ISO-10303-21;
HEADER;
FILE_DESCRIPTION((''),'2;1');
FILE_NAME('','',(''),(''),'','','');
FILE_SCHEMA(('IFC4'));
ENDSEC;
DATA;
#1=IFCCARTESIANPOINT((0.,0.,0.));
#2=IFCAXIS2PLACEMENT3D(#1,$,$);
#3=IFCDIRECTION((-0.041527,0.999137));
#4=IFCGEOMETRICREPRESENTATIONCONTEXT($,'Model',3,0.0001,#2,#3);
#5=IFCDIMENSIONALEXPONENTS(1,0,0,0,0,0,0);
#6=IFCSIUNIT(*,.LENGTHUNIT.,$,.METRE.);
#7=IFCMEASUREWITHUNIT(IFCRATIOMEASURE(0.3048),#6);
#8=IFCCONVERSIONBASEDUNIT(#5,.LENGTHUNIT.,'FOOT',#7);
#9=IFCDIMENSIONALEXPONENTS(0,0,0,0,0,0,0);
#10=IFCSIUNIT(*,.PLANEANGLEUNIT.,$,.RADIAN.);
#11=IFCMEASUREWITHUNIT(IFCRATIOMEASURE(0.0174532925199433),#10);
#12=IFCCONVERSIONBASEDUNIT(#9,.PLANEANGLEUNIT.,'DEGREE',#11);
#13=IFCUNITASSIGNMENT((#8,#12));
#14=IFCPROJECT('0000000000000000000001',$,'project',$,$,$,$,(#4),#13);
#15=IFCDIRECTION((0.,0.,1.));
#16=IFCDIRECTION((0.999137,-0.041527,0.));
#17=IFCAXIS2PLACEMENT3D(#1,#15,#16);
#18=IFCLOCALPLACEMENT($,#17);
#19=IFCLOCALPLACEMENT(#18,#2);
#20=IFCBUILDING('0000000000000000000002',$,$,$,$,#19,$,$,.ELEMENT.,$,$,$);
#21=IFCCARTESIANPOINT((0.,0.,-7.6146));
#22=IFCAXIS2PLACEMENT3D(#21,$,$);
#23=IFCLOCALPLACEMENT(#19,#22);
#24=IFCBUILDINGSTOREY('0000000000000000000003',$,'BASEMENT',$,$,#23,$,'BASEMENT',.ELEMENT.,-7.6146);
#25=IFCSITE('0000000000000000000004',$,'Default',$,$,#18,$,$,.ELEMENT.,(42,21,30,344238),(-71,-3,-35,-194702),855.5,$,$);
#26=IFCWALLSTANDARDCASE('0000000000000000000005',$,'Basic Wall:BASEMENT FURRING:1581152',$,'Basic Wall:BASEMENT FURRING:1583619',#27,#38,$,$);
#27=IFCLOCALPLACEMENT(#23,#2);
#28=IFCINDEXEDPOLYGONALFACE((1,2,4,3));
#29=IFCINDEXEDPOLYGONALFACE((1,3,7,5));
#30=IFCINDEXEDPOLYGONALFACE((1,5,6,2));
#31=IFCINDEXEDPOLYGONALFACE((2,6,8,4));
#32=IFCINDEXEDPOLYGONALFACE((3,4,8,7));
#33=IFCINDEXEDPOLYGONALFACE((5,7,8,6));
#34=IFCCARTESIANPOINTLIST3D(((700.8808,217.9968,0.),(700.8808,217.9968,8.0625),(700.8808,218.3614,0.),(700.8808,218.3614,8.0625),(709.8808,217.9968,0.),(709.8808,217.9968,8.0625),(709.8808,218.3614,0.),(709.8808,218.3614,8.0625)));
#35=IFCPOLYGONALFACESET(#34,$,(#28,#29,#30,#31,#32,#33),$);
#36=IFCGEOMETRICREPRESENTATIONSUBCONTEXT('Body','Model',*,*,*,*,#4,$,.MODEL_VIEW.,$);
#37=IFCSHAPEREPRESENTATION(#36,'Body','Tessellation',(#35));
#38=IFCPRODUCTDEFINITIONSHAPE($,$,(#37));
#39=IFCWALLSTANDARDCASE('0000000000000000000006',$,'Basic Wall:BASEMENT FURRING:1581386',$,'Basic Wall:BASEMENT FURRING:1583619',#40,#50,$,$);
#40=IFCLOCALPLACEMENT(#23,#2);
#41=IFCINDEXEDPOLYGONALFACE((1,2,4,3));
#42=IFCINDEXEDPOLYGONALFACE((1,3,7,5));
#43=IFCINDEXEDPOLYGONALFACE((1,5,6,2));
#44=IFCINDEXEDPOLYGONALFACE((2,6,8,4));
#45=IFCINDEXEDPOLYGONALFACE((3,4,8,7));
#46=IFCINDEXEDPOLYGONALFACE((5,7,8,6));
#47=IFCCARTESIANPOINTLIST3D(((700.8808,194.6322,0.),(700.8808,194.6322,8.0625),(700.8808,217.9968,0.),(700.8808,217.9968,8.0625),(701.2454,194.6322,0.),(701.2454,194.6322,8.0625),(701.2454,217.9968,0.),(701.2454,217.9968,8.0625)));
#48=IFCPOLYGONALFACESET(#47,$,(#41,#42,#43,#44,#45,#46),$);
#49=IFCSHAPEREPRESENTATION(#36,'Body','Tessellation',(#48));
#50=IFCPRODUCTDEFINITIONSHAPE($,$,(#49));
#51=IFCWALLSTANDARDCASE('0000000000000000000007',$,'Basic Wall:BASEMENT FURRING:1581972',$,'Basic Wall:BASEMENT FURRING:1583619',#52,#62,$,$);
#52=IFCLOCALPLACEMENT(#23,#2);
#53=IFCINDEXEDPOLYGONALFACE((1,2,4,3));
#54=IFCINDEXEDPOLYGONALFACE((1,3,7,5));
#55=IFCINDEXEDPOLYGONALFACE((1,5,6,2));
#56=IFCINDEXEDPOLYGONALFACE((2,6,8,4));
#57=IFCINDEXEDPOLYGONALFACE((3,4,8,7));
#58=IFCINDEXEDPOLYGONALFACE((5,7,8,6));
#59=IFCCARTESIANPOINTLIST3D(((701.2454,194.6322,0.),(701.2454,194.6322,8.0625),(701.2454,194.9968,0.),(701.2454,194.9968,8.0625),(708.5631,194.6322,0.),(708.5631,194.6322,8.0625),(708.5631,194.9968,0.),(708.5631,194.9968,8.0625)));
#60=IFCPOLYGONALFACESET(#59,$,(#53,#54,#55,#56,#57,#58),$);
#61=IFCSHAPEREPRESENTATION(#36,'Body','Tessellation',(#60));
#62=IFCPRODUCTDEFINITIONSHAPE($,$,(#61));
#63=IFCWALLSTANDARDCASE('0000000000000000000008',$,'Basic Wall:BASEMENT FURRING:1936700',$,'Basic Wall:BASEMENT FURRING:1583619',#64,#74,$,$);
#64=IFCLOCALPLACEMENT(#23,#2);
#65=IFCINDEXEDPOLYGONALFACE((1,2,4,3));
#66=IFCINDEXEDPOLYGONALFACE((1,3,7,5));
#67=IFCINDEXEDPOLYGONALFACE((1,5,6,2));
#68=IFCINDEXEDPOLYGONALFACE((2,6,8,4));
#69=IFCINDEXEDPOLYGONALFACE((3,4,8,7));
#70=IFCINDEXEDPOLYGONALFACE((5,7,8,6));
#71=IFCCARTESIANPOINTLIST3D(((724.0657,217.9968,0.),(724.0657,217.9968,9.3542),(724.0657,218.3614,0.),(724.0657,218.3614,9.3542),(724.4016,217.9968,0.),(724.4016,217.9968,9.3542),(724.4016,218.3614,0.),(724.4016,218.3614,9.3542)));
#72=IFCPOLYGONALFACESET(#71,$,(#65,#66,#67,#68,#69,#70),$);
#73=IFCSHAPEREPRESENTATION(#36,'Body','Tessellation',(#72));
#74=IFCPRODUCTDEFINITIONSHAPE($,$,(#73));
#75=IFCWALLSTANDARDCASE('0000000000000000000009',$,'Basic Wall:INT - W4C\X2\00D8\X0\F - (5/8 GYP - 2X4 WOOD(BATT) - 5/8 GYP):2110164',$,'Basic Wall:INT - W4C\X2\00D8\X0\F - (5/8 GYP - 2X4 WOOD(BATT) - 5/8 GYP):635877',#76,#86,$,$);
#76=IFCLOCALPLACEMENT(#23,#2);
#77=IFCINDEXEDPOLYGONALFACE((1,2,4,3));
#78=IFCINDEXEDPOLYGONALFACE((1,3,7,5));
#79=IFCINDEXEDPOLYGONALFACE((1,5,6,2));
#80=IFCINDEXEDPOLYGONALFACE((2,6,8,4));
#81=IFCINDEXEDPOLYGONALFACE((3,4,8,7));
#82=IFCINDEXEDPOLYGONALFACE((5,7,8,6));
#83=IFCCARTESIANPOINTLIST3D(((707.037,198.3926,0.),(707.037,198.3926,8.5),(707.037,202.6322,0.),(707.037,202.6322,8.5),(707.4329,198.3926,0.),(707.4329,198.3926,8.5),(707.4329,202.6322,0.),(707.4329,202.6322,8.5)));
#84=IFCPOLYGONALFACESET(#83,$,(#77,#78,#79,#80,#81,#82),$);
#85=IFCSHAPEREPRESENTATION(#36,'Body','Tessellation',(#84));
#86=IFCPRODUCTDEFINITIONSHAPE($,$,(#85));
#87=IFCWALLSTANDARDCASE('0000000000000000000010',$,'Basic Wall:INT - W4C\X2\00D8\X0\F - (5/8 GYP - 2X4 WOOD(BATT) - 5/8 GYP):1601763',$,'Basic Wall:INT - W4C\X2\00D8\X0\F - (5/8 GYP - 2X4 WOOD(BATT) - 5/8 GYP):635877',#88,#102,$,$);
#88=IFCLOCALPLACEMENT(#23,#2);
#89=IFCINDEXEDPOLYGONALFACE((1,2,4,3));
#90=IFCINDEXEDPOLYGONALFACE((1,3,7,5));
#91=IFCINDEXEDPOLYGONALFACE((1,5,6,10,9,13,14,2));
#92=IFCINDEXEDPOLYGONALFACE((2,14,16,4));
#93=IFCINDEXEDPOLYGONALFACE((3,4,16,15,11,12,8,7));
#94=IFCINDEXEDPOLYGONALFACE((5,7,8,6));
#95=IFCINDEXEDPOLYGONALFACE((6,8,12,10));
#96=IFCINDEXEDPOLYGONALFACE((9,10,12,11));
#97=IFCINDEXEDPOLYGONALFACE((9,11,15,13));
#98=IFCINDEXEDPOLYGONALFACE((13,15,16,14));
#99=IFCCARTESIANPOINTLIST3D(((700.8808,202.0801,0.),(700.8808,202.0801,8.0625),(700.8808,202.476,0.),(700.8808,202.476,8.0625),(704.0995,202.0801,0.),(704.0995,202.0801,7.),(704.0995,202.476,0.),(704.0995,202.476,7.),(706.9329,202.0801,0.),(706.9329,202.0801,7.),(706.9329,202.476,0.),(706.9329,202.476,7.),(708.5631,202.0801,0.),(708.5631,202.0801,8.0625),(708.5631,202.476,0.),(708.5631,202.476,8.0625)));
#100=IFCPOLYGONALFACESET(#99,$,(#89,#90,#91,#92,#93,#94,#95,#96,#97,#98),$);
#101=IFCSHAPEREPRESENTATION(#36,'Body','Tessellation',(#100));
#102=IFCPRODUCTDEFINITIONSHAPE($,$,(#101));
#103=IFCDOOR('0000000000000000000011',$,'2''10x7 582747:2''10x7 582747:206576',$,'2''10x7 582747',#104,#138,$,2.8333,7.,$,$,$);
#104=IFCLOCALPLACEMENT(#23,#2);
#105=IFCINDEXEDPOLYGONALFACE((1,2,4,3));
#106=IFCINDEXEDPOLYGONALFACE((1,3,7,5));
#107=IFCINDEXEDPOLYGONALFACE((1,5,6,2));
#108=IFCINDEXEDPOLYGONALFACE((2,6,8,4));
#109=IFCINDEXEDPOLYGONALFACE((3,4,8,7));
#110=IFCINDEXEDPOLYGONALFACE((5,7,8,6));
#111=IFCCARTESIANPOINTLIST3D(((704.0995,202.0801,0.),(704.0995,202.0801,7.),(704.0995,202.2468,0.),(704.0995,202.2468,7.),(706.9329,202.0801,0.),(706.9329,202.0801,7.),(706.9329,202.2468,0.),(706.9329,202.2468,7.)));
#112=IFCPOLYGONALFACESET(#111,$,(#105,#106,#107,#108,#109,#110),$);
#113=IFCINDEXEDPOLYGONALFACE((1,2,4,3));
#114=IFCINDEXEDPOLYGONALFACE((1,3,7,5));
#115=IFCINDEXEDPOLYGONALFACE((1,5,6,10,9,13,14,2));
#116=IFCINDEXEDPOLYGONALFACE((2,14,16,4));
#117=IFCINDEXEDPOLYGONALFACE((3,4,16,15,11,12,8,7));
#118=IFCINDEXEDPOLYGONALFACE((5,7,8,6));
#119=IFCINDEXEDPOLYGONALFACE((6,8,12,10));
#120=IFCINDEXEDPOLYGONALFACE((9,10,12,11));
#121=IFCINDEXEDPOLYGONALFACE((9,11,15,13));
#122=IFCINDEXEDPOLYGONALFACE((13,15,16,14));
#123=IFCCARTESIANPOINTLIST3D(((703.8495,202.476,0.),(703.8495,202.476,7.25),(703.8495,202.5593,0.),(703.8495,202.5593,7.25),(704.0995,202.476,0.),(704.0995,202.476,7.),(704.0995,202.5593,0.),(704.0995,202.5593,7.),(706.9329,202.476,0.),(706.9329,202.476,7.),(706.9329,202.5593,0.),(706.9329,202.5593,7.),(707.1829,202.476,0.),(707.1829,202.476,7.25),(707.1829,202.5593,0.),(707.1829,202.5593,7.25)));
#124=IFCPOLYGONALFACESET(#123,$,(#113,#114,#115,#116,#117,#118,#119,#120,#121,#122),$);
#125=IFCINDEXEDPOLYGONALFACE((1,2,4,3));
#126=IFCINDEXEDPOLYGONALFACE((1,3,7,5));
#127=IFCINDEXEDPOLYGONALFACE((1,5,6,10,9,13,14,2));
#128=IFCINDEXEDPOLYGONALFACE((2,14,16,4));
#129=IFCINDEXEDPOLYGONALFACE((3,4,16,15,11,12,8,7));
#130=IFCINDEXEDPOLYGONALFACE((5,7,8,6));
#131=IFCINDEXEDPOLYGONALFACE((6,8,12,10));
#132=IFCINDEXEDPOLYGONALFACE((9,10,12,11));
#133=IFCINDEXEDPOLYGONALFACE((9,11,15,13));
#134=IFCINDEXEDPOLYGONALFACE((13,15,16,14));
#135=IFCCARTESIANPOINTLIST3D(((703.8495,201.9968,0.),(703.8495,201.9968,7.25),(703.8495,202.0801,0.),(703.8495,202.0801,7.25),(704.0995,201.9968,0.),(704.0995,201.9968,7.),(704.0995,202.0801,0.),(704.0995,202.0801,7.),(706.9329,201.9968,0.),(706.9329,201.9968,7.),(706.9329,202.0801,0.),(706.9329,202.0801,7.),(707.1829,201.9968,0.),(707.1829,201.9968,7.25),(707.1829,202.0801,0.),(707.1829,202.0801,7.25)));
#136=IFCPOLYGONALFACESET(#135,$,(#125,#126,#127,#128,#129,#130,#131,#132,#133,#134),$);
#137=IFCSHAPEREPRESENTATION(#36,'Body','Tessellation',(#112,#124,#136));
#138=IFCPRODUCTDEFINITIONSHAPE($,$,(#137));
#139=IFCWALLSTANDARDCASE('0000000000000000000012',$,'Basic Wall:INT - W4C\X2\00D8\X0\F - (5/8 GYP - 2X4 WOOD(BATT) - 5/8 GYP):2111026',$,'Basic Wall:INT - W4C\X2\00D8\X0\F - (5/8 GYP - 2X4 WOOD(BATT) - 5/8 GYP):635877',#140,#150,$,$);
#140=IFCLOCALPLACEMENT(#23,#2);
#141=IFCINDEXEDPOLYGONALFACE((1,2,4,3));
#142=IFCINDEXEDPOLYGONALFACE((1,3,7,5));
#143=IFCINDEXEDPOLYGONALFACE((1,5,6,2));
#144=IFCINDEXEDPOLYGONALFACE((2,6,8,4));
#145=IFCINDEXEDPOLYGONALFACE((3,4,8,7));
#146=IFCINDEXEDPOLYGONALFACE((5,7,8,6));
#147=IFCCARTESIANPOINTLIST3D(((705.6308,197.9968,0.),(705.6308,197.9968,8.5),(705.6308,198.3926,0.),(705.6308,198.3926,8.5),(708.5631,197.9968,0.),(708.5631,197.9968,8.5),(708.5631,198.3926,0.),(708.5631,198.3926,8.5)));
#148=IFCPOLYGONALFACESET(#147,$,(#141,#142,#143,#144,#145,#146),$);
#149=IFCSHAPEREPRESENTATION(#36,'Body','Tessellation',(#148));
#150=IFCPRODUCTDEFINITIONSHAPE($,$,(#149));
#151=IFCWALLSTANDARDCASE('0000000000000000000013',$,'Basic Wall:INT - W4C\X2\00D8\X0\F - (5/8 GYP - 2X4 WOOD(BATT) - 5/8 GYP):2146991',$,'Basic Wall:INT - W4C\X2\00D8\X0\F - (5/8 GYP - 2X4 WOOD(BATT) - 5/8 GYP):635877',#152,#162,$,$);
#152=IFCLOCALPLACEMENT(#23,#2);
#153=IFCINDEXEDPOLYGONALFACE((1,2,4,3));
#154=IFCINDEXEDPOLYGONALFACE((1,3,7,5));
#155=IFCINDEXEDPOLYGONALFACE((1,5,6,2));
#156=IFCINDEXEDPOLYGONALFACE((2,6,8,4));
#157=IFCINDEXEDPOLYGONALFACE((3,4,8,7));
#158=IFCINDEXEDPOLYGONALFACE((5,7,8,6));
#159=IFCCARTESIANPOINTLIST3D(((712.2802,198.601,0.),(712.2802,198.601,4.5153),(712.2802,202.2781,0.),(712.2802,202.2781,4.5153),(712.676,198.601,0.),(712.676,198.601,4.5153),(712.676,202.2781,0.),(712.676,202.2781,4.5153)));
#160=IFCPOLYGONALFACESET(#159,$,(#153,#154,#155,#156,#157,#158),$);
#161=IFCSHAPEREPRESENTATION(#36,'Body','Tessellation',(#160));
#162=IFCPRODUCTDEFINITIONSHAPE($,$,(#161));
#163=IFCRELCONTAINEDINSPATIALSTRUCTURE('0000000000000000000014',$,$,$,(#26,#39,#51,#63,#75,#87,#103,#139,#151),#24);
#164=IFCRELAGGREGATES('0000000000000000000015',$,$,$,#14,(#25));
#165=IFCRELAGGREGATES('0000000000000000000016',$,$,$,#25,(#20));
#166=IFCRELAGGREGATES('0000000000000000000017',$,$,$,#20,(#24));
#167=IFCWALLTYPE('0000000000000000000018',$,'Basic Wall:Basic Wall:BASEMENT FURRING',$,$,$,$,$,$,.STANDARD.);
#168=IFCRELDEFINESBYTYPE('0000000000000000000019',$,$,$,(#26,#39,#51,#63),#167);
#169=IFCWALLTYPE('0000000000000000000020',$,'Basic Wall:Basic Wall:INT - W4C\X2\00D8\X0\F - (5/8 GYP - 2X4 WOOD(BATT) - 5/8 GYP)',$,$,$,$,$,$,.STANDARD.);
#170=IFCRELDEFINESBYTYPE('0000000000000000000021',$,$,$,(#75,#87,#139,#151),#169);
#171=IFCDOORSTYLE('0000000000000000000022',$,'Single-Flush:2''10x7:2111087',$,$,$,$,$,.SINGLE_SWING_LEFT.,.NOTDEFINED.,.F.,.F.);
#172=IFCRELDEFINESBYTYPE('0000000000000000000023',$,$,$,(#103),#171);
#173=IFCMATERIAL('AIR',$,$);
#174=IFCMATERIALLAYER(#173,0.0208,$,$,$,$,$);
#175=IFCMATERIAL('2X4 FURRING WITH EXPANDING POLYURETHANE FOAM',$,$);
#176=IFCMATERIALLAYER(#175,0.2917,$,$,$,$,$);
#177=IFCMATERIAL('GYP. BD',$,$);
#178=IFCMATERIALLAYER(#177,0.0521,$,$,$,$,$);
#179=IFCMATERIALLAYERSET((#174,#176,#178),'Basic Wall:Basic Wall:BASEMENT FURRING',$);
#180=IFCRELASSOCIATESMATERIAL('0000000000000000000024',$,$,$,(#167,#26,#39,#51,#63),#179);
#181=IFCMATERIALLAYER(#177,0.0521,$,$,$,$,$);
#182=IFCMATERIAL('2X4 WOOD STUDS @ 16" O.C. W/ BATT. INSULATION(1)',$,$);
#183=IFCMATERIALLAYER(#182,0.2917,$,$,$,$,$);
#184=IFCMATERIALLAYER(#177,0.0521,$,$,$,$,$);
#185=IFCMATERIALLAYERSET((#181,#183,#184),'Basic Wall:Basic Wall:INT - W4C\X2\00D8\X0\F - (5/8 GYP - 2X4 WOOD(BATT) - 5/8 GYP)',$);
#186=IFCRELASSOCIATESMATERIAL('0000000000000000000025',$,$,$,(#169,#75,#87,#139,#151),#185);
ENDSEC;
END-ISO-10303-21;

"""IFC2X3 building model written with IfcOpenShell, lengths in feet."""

from ifc_helpers import new_model, entity, si_unit, converted_unit, direction, frame, frame_2d, origin, place, context, subcontext, project, spatial, polyline, rectangle, outline, extrude, source, transform, mapped, material, layer, layer_set, layer_usage, type_object, type_shapes, element, fill, save


model = new_model("IFC2X3")

# Units and contexts
model_context = context("Model", 3, precision=0.0001, world=origin(), true_north=direction((-0.041527, 0.999137)))
body_context = subcontext(model_context, "Body", "Model", "MODEL_VIEW")
ifc_project = project(units=[converted_unit("LENGTHUNIT", "FOOT", entity("IfcRatioMeasure", 0.3048), si_unit("LENGTHUNIT", "METRE"), dimensions=[1, 0, 0, 0, 0, 0, 0]), converted_unit("PLANEANGLEUNIT", "DEGREE", entity("IfcRatioMeasure", 0.0174532925199433), si_unit("PLANEANGLEUNIT", "RADIAN"), dimensions=[0, 0, 0, 0, 0, 0, 0])], contexts=[model_context])

# Site, building, storey
site_placement = place(None, frame((0.0, 0.0, 0.0), z_axis=(0.0, 0.0, 1.0), x_axis=(0.999137, -0.041527, 0.0)))
site = spatial("IfcSite", under=ifc_project, at=site_placement, Name="Default", CompositionType="ELEMENT", RefLatitude=(42, 21, 30, 344238), RefLongitude=(-71, -3, -35, -194702), RefElevation=855.5)
building_placement = place(site_placement, origin())
building = spatial("IfcBuilding", under=site, at=building_placement, CompositionType="ELEMENT")
storey_placement = place(building_placement, frame((0.0, 0.0, -7.6146)))
storey = spatial("IfcBuildingStorey", under=building, at=storey_placement, Name="BASEMENT", LongName="BASEMENT", CompositionType="ELEMENT", Elevation=-7.6146)

# Shared definitions
ifc_material_1 = material(Name="AIR")
ifc_layer_1 = layer(ifc_material_1, 0.0208)
ifc_material_2 = material(Name="2X4 FURRING WITH EXPANDING POLYURETHANE FOAM")
ifc_layer_2 = layer(ifc_material_2, 0.2917)
ifc_material_3 = material(Name="GYP. BD")
ifc_layer_3 = layer(ifc_material_3, 0.0521)
ifc_layer_set_1 = layer_set([ifc_layer_1, ifc_layer_2, ifc_layer_3], Name="Basic Wall:Basic Wall:BASEMENT FURRING")
wall_type_1 = type_object("IfcWallType", Name="Basic Wall:Basic Wall:BASEMENT FURRING", PredefinedType="STANDARD", material=ifc_layer_set_1)

# Walls
ifc_layer_usage_1 = layer_usage(ifc_layer_set_1, "AXIS2", "NEGATIVE", 0.1823)
wall_1_placement = place(storey_placement, frame((700.8808, 218.1791, 0.0)))
element("IfcWallStandardCase", 1, at=wall_1_placement, inside=storey, type_object=wall_type_1, material=ifc_layer_usage_1, Name="Basic Wall:BASEMENT FURRING:1581152", ObjectType="Basic Wall:BASEMENT FURRING:1583619", context=body_context, shape_type="SweptSolid", body=[
    extrude(rectangle(XDim=9.0, YDim=0.3646, at=frame_2d((4.5, 0.0), x_axis=(-1.0, 0.0))), origin(), (0.0, 0.0, 1.0), 8.0625),
])
ifc_layer_usage_2 = layer_usage(ifc_layer_set_1, "AXIS2", "NEGATIVE", 0.1823)
wall_2_placement = place(storey_placement, frame((701.0631, 194.6322, 0.0), z_axis=(0.0, 0.0, 1.0), x_axis=(0.0, 1.0, 0.0)))
element("IfcWallStandardCase", 2, at=wall_2_placement, inside=storey, type_object=wall_type_1, material=ifc_layer_usage_2, Name="Basic Wall:BASEMENT FURRING:1581386", ObjectType="Basic Wall:BASEMENT FURRING:1583619", context=body_context, shape_type="SweptSolid", body=[
    extrude(rectangle(XDim=23.3646, YDim=0.3646, at=frame_2d((11.6823, 0.0), x_axis=(-1.0, 0.0))), origin(), (0.0, 0.0, 1.0), 8.0625),
])
ifc_layer_usage_3 = layer_usage(ifc_layer_set_1, "AXIS2", "NEGATIVE", 0.1823)
wall_3_placement = place(storey_placement, frame((708.5631, 194.8145, 0.0), z_axis=(0.0, 0.0, 1.0), x_axis=(-1.0, 0.0, 0.0)))
element("IfcWallStandardCase", 3, at=wall_3_placement, inside=storey, type_object=wall_type_1, material=ifc_layer_usage_3, Name="Basic Wall:BASEMENT FURRING:1581972", ObjectType="Basic Wall:BASEMENT FURRING:1583619", context=body_context, shape_type="SweptSolid", body=[
    extrude(rectangle(XDim=7.3177, YDim=0.3646, at=frame_2d((3.6589, 0.0), x_axis=(-1.0, 0.0))), origin(), (0.0, 0.0, 1.0), 8.0625),
])
ifc_layer_usage_4 = layer_usage(ifc_layer_set_1, "AXIS2", "NEGATIVE", 0.1823)
wall_4_placement = place(storey_placement, frame((724.0657, 218.1791, 0.0)))
element("IfcWallStandardCase", 4, at=wall_4_placement, inside=storey, type_object=wall_type_1, material=ifc_layer_usage_4, Name="Basic Wall:BASEMENT FURRING:1936700", ObjectType="Basic Wall:BASEMENT FURRING:1583619", context=body_context, shape_type="SweptSolid", body=[
    extrude(rectangle(XDim=0.3359, YDim=0.3646, at=frame_2d((0.1679, 0.0), x_axis=(-1.0, 0.0))), origin(), (0.0, 0.0, 1.0), 9.3542),
])
ifc_layer_4 = layer(ifc_material_3, 0.0521)
ifc_material_4 = material(Name="2X4 WOOD STUDS @ 16\" O.C. W/ BATT. INSULATION(1)")
ifc_layer_5 = layer(ifc_material_4, 0.2917)
ifc_layer_6 = layer(ifc_material_3, 0.0521)
ifc_layer_set_2 = layer_set([ifc_layer_4, ifc_layer_5, ifc_layer_6], Name="Basic Wall:Basic Wall:INT - W4CØF - (5/8 GYP - 2X4 WOOD(BATT) - 5/8 GYP)")
ifc_layer_usage_5 = layer_usage(ifc_layer_set_2, "AXIS2", "NEGATIVE", 0.1979)
wall_type_2 = type_object("IfcWallType", Name="Basic Wall:Basic Wall:INT - W4CØF - (5/8 GYP - 2X4 WOOD(BATT) - 5/8 GYP)", PredefinedType="STANDARD", material=ifc_layer_set_2)
wall_5_placement = place(storey_placement, frame((707.2349, 198.3926, 0.0), z_axis=(0.0, 0.0, 1.0), x_axis=(0.0, 1.0, 0.0)))
element("IfcWallStandardCase", 5, at=wall_5_placement, inside=storey, type_object=wall_type_2, material=ifc_layer_usage_5, Name="Basic Wall:INT - W4CØF - (5/8 GYP - 2X4 WOOD(BATT) - 5/8 GYP):2110164", ObjectType="Basic Wall:INT - W4CØF - (5/8 GYP - 2X4 WOOD(BATT) - 5/8 GYP):635877", context=body_context, shape_type="SweptSolid", body=[
    extrude(rectangle(XDim=4.2396, YDim=0.3958, at=frame_2d((2.1198, 0.0), x_axis=(-1.0, 0.0))), origin(), (0.0, 0.0, 1.0), 8.5),
])

# Wall, opening, door
ifc_layer_usage_6 = layer_usage(ifc_layer_set_2, "AXIS2", "NEGATIVE", 0.1979)
wall_6_placement = place(storey_placement, frame((708.5631, 202.2781, 0.0), z_axis=(0.0, 0.0, 1.0), x_axis=(-1.0, 0.0, 0.0)))
wall_6 = element("IfcWallStandardCase", 6, at=wall_6_placement, inside=storey, type_object=wall_type_2, material=ifc_layer_usage_6, Name="Basic Wall:INT - W4CØF - (5/8 GYP - 2X4 WOOD(BATT) - 5/8 GYP):1601763", ObjectType="Basic Wall:INT - W4CØF - (5/8 GYP - 2X4 WOOD(BATT) - 5/8 GYP):635877", context=body_context, shape_type="SweptSolid", body=[
    extrude(rectangle(XDim=7.6823, YDim=0.3958, at=frame_2d((3.8411, 0.0), x_axis=(-1.0, 0.0))), origin(), (0.0, 0.0, 1.0), 8.0625),
])
opening_1_placement = place(wall_6_placement, frame((708.5631, 202.2781, 0.0), z_axis=(0.0, 0.0, 1.0), x_axis=(-1.0, 0.0, 0.0)))
opening_1 = element("IfcOpeningElement", 7, at=opening_1_placement, cuts=wall_6, ObjectType="Opening", context=body_context, shape_type="SweptSolid", body=[
    extrude(rectangle(XDim=7.0, YDim=2.8333, at=frame_2d((0.0, 0.0), x_axis=(1.0, 0.0))), frame((705.5162, 202.4799, 3.5), z_axis=(0.0, -1.0, 0.0), x_axis=(0.0, 0.0, 1.0)), (0.0, 0.0, 1.0), 0.4038),
])
door_style_1 = type_object("IfcDoorStyle", Name="Single-Flush:2'10x7:2111087", ConstructionType="NOTDEFINED", OperationType="SINGLE_SWING_LEFT", ParameterTakesPrecedence=False, Sizeable=False)
shared_shape_1 = source(origin(), body_context, "Body", "SweptSolid", [
    extrude(rectangle(XDim=0.1667, YDim=2.8333, at=frame_2d((0.0, 0.0), x_axis=(1.0, 0.0))), frame((1.4167, -0.0873, 0.0), z_axis=(0.0, 0.0, 1.0), x_axis=(0.0, 1.0, 0.0)), (0.0, 0.0, 1.0), 7.0),
    extrude(outline(polyline([(-3.5625, -1.6667), (3.6875, -1.6667), (3.6875, 1.6667), (-3.5625, 1.6667), (-3.5625, 1.4167), (3.4375, 1.4167), (3.4375, -1.4167), (-3.5625, -1.4167), (-3.5625, -1.6667)])), frame((1.4167, -0.4831, 3.5625), z_axis=(0.0, 1.0, 0.0), x_axis=(0.0, 0.0, 1.0)), (0.0, 0.0, 1.0), 0.0833),
    extrude(outline(polyline([(-1.6667, -3.6875), (1.6667, -3.6875), (1.6667, 3.5625), (1.4167, 3.5625), (1.4167, -3.4375), (-1.4167, -3.4375), (-1.4167, 3.5625), (-1.6667, 3.5625), (-1.6667, -3.6875)])), frame((1.4167, -0.004, 3.5625), z_axis=(0.0, 1.0, 0.0), x_axis=(1.0, 0.0, 0.0)), (0.0, 0.0, 1.0), 0.0833),
])
type_shapes(door_style_1, [shared_shape_1])
door_1_placement = place(opening_1_placement, frame((706.9329, 202.0762, 0.0), z_axis=(0.0, 0.0, 1.0), x_axis=(-1.0, 0.0, 0.0)))
door_1 = element("IfcDoor", 8, at=door_1_placement, inside=storey, type_object=door_style_1, Name="2'10x7 582747:2'10x7 582747:206576", ObjectType="2'10x7 582747", OverallHeight=2.8333, OverallWidth=7.0, context=body_context, shape_type="MappedRepresentation", body=[
    mapped(shared_shape_1, transform((0.0, 0.0, 0.0), scale=1.0)),
])
fill(opening_1, door_1)

# Walls
ifc_layer_usage_7 = layer_usage(ifc_layer_set_2, "AXIS2", "NEGATIVE", 0.1979)
wall_7_placement = place(storey_placement, frame((705.6308, 198.1947, 0.0)))
element("IfcWallStandardCase", 9, at=wall_7_placement, inside=storey, type_object=wall_type_2, material=ifc_layer_usage_7, Name="Basic Wall:INT - W4CØF - (5/8 GYP - 2X4 WOOD(BATT) - 5/8 GYP):2111026", ObjectType="Basic Wall:INT - W4CØF - (5/8 GYP - 2X4 WOOD(BATT) - 5/8 GYP):635877", context=body_context, shape_type="SweptSolid", body=[
    extrude(rectangle(XDim=2.9323, YDim=0.3958, at=frame_2d((1.4661, 0.0), x_axis=(-1.0, 0.0))), origin(), (0.0, 0.0, 1.0), 8.5),
])
ifc_layer_usage_8 = layer_usage(ifc_layer_set_2, "AXIS2", "NEGATIVE", 0.1979)
wall_8_placement = place(storey_placement, frame((712.4781, 202.2781, 0.0), z_axis=(0.0, 0.0, 1.0), x_axis=(0.0, -1.0, 0.0)))
element("IfcWallStandardCase", 10, at=wall_8_placement, inside=storey, type_object=wall_type_2, material=ifc_layer_usage_8, Name="Basic Wall:INT - W4CØF - (5/8 GYP - 2X4 WOOD(BATT) - 5/8 GYP):2146991", ObjectType="Basic Wall:INT - W4CØF - (5/8 GYP - 2X4 WOOD(BATT) - 5/8 GYP):635877", context=body_context, shape_type="SweptSolid", body=[
    extrude(rectangle(XDim=3.6771, YDim=0.3958, at=frame_2d((1.8385, 0.0), x_axis=(-1.0, 0.0))), origin(), (0.0, 0.0, 1.0), 4.5153),
])

save(model, "model.ifc")
